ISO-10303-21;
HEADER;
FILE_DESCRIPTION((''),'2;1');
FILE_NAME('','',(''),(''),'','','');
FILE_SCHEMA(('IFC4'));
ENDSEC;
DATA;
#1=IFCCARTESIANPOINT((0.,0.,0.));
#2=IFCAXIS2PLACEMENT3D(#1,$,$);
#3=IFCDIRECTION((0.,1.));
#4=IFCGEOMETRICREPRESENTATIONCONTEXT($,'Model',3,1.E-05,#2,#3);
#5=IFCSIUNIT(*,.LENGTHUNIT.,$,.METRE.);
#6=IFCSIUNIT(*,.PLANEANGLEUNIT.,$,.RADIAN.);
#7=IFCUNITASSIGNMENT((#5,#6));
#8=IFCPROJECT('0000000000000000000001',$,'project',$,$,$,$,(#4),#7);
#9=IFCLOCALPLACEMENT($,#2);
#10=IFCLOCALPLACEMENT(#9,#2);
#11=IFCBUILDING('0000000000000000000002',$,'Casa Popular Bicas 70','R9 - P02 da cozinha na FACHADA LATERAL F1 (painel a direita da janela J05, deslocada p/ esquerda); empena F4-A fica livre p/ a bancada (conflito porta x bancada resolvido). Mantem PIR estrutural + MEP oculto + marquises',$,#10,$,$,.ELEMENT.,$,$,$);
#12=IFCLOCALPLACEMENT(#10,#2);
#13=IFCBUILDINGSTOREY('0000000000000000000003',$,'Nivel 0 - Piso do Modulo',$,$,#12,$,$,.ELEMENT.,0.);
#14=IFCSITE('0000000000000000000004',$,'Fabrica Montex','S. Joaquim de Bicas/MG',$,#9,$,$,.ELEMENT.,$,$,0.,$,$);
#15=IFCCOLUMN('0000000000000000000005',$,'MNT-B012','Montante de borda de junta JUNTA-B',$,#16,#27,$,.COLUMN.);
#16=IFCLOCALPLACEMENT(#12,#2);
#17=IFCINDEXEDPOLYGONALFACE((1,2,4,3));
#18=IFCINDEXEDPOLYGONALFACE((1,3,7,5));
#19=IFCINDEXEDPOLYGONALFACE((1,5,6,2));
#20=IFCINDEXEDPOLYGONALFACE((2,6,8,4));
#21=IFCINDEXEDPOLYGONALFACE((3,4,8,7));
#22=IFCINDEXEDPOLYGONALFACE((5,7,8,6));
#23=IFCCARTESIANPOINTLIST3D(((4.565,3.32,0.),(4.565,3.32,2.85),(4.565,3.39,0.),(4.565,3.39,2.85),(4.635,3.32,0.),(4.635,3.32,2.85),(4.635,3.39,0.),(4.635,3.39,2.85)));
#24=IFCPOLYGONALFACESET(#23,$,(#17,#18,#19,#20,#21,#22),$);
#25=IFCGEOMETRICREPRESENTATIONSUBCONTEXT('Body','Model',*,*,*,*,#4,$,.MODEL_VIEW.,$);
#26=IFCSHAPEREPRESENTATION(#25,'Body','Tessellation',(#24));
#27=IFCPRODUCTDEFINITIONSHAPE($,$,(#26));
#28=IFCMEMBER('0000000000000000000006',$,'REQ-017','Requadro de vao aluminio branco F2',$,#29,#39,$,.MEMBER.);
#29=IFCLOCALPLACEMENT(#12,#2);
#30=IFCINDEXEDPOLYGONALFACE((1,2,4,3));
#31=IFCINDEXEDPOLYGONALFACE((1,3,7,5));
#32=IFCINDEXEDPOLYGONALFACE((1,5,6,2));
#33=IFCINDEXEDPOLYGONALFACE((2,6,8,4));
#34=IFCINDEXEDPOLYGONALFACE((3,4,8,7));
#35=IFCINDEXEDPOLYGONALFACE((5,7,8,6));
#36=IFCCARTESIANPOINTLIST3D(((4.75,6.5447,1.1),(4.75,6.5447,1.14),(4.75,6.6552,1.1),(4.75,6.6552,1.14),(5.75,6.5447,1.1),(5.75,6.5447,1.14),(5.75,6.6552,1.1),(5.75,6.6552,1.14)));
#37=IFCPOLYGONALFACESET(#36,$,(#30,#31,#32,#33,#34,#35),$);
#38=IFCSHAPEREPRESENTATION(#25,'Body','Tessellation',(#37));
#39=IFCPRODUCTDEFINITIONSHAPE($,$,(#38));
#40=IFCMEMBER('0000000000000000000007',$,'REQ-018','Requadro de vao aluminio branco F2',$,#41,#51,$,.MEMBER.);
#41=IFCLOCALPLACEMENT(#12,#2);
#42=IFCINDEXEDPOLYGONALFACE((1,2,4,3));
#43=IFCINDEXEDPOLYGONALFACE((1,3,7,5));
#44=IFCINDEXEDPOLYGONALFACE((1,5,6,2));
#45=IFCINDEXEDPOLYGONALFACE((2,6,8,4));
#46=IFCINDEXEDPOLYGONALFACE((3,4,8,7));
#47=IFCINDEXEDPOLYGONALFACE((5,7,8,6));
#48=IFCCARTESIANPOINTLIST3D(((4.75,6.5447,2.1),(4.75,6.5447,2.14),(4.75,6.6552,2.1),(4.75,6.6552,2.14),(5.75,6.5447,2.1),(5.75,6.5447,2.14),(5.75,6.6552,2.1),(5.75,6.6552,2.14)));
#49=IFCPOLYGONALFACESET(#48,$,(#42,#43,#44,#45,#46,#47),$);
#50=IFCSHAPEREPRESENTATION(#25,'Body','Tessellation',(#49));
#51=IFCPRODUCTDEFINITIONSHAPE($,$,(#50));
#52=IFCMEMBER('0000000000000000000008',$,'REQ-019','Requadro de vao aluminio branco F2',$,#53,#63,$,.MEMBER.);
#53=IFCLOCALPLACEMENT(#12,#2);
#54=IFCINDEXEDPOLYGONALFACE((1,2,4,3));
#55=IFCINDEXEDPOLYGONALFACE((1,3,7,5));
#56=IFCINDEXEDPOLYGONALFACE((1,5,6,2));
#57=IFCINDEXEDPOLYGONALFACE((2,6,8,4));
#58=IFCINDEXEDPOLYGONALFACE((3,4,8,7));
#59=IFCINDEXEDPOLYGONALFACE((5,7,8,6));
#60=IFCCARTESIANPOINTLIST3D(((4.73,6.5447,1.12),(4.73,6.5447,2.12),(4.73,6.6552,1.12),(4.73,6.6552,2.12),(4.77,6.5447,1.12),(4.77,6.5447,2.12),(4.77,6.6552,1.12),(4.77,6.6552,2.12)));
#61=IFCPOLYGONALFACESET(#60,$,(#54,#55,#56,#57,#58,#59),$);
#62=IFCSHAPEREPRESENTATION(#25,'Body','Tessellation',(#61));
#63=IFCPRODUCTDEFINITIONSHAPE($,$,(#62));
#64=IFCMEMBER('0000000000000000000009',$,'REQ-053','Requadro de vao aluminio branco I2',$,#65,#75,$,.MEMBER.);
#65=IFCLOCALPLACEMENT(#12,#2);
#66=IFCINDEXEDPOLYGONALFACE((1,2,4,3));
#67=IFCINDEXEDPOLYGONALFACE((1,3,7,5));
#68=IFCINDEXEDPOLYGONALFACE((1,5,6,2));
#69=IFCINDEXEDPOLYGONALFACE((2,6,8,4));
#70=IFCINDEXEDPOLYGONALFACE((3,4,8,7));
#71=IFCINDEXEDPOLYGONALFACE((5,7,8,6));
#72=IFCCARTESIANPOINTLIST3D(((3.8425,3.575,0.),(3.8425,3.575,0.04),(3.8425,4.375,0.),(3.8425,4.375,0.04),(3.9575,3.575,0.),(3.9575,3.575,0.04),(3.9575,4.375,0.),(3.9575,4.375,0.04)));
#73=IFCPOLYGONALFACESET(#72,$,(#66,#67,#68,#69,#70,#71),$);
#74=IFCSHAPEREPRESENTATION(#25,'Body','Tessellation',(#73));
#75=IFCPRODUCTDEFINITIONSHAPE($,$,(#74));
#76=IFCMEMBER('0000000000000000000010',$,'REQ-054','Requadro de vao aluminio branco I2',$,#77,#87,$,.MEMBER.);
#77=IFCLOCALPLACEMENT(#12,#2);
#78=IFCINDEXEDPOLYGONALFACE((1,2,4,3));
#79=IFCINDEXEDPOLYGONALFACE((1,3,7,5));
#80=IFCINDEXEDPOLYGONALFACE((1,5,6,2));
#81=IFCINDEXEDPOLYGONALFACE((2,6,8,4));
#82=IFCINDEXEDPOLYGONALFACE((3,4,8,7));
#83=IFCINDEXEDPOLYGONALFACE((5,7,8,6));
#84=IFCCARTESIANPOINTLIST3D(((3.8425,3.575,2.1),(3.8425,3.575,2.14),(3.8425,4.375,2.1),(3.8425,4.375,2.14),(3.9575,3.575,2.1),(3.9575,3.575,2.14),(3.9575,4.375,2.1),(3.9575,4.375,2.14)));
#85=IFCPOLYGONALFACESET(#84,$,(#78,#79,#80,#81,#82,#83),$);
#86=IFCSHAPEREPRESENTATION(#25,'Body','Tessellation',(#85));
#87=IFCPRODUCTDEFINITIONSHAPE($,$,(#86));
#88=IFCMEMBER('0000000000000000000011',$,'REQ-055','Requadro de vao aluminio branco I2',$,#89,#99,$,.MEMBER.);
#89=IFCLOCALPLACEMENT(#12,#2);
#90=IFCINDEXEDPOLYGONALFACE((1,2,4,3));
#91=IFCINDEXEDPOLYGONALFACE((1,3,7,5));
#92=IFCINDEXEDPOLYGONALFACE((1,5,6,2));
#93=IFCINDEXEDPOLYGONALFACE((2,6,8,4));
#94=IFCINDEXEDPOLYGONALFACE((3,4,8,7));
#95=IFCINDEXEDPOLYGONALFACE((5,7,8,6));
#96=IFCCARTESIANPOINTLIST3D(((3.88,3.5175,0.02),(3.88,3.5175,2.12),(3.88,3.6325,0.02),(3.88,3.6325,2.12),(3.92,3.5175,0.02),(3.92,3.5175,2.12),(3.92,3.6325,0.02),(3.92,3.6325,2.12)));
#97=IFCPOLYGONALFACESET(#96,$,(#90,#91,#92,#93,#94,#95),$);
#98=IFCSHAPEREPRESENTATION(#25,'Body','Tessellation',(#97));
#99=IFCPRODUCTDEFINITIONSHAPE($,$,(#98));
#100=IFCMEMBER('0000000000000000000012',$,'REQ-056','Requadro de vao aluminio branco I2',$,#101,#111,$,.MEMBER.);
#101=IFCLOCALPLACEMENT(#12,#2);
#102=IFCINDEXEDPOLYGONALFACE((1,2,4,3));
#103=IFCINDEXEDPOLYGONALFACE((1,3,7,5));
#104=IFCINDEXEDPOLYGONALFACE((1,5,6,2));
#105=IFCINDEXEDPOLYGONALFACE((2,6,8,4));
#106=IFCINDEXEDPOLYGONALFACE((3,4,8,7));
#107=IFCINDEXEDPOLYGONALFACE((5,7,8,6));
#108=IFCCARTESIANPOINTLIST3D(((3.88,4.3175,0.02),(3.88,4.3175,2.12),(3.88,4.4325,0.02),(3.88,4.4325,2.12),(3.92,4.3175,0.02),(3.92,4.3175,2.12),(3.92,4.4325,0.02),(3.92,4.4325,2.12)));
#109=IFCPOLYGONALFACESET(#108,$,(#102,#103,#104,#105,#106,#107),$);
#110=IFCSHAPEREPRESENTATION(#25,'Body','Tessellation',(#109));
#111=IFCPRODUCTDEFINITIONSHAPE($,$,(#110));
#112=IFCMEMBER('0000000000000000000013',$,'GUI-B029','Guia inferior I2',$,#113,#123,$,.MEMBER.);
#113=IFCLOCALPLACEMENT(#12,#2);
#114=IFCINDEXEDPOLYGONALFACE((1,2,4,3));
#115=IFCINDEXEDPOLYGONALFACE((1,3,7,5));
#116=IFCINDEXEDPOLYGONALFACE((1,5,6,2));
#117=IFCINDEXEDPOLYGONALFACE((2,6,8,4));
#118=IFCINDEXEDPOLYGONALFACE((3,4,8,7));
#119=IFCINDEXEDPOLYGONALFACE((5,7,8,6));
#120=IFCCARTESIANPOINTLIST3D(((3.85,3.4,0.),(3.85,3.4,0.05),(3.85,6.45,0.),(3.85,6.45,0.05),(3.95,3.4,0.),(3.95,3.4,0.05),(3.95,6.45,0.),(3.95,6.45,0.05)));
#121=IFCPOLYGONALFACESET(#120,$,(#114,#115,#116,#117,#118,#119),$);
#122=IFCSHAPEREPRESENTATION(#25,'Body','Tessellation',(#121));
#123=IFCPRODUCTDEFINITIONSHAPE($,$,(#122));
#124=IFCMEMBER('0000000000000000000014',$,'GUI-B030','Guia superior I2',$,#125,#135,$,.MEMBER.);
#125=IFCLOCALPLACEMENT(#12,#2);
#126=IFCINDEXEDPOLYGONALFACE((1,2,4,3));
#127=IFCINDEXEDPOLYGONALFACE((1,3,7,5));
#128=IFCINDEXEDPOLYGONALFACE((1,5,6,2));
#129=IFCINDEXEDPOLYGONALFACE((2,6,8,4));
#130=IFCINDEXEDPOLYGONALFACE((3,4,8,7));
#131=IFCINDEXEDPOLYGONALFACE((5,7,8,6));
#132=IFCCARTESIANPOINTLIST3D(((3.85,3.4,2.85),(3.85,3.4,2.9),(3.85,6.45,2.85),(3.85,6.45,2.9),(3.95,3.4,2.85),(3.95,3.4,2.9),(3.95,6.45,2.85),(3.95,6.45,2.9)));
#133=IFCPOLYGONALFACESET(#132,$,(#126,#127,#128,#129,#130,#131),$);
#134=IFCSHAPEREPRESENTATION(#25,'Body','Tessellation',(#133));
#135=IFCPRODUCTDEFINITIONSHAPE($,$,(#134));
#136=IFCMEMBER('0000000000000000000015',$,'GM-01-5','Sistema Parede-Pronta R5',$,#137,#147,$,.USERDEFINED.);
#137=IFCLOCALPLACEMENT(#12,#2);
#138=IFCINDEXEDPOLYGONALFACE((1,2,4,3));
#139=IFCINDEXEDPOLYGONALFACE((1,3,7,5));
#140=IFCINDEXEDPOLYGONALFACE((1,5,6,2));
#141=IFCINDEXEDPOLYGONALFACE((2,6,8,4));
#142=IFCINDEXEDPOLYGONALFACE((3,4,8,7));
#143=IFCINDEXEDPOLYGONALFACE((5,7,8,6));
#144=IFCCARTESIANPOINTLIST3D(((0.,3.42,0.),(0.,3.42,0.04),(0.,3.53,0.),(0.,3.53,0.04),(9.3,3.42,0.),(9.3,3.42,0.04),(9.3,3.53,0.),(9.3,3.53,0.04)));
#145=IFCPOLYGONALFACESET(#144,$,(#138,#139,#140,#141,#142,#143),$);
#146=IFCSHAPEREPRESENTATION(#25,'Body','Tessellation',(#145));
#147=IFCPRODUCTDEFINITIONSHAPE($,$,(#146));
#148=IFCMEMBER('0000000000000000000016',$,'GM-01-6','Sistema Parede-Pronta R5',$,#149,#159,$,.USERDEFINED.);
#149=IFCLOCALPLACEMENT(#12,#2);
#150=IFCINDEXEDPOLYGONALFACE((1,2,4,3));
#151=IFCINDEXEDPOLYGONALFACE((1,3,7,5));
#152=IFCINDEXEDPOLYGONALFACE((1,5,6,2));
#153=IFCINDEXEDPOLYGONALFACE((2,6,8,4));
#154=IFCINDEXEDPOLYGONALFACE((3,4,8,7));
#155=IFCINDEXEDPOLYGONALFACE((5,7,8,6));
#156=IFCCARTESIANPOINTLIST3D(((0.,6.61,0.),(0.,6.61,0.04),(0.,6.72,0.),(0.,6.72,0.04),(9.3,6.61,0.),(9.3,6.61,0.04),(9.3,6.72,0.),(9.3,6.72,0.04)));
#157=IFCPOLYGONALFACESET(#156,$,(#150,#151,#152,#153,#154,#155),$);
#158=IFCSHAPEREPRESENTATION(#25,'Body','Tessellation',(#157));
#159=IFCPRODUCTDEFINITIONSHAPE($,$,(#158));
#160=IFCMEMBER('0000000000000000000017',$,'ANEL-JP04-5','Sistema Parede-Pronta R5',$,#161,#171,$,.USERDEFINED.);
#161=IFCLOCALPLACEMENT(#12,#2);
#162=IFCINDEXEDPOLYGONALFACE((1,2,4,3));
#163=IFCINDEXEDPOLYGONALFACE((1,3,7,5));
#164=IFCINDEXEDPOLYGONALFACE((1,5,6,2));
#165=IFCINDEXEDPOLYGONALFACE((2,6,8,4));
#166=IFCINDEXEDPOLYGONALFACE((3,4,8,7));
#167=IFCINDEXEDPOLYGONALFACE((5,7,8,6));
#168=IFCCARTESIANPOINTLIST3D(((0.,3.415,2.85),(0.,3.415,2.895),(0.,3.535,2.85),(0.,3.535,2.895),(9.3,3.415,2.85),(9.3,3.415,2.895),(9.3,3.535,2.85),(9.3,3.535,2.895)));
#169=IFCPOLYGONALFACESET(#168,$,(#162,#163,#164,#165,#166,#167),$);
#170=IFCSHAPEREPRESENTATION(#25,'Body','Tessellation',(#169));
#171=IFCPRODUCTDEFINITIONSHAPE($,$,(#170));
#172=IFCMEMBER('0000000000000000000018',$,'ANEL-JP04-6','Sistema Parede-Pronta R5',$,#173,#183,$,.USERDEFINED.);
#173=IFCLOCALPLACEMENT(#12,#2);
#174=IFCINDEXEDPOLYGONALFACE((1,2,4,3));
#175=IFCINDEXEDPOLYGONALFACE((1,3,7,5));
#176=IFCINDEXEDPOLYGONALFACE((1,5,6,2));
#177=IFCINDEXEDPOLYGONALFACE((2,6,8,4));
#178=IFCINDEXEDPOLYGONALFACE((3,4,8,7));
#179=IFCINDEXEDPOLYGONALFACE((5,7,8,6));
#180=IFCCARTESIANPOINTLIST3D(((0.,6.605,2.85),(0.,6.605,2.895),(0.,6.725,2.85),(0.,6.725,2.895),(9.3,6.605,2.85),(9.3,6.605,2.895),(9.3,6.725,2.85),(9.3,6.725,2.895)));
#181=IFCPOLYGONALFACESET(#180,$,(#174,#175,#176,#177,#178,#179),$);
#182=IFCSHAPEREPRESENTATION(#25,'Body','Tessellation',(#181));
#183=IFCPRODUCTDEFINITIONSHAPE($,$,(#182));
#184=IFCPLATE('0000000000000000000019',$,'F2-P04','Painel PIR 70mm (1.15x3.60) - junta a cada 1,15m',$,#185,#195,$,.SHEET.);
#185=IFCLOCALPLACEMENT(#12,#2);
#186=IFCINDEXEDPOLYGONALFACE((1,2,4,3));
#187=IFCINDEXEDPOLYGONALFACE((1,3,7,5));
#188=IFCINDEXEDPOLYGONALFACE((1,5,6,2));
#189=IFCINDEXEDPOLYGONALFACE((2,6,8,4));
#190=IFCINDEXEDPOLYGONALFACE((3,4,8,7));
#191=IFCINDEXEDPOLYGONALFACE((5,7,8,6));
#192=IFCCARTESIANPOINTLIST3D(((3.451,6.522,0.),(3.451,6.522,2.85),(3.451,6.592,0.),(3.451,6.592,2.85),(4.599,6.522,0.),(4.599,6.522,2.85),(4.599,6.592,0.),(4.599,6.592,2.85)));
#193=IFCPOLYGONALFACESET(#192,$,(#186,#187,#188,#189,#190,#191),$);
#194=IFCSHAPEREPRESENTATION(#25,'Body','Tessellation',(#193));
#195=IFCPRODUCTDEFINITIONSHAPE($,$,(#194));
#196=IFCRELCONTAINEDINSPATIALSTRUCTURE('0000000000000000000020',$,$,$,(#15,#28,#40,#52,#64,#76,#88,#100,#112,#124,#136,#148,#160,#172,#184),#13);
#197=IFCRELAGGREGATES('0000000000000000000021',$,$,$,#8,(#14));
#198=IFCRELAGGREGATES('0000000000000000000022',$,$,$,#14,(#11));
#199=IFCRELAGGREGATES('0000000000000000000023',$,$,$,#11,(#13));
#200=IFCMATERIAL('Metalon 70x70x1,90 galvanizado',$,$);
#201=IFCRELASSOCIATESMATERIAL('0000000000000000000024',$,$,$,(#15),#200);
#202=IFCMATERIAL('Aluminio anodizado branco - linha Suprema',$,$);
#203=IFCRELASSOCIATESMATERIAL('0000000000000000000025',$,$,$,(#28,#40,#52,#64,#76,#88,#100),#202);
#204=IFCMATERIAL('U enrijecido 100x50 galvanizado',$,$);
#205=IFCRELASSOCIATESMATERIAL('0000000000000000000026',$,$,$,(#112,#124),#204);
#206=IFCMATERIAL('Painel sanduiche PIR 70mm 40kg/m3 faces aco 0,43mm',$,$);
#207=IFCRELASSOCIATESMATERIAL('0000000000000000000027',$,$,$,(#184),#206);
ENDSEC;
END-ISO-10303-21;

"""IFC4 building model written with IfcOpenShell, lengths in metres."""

from ifc_helpers import new_model, si_unit, direction, frame, frame_2d, origin, origin_2d, place, context, subcontext, project, spatial, rectangle, extrude, material, element, save


model = new_model("IFC4")

# Units and contexts
model_context = context("Model", 3, precision=1e-05, world=origin(), true_north=direction((0.0, 1.0)))
body_context = subcontext(model_context, "Body", "Model", "MODEL_VIEW")
ifc_project = project(units=[si_unit("LENGTHUNIT", "METRE"), si_unit("PLANEANGLEUNIT", "RADIAN")], contexts=[model_context])

# Site, building, storey
site_placement = place(None, origin())
site = spatial("IfcSite", under=ifc_project, at=site_placement, Name="Fabrica Montex", Description="S. Joaquim de Bicas/MG", CompositionType="ELEMENT", RefElevation=0.0)
building_placement = place(site_placement, origin())
building = spatial("IfcBuilding", under=site, at=building_placement, Name="Casa Popular Bicas 70", Description="R9 - P02 da cozinha na FACHADA LATERAL F1 (painel a direita da janela J05, deslocada p/ esquerda); empena F4-A fica livre p/ a bancada (conflito porta x bancada resolvido). Mantem PIR estrutural + MEP oculto + marquises", CompositionType="ELEMENT")
storey_placement = place(building_placement, origin())
storey = spatial("IfcBuildingStorey", under=building, at=storey_placement, Name="Nivel 0 - Piso do Modulo", CompositionType="ELEMENT", Elevation=0.0)

# Column
ifc_material_1 = material(Name="Metalon 70x70x1,90 galvanizado")
column_placement = place(storey_placement, frame((4.6, 3.355, 0.0)))
element("IfcColumn", 1, at=column_placement, inside=storey, material=ifc_material_1, Name="MNT-B012", Description="Montante de borda de junta JUNTA-B", PredefinedType="COLUMN", context=body_context, shape_type="SweptSolid", body=[
    extrude(rectangle(XDim=0.07, YDim=0.07, at=origin_2d()), origin(), (0.0, 0.0, 1.0), 2.85),
])

# Members
ifc_material_2 = material(Name="Aluminio anodizado branco - linha Suprema")
for number, where, z_axis, x_axis, name in (
    (2, (4.75, 6.6, 1.12), (1.0, 0.0, 0.0), (0.0, 0.0, 1.0), "REQ-017"),
    (3, (4.75, 6.6, 2.12), (1.0, 0.0, 0.0), (0.0, 0.0, 1.0), "REQ-018"),
    (4, (4.75, 6.6, 1.12), (0.0, 0.0, 1.0), (1.0, 0.0, 0.0), "REQ-019"),
):
    element("IfcMember", number, at=place(storey_placement, frame(where, z_axis=z_axis, x_axis=x_axis)), inside=storey, material=ifc_material_2, Name=name, Description="Requadro de vao aluminio branco F2", PredefinedType="MEMBER", context=body_context, shape_type="SweptSolid", body=[
        extrude(rectangle(XDim=0.04, YDim=0.1105, at=origin_2d()), origin(), (0.0, 0.0, 1.0), 1.0),
    ])
for number, where, z_axis, x_axis, name in (
    (5, (3.9, 3.575, 0.02), (0.0, 1.0, 0.0), (0.0, 0.0, 1.0), "REQ-053"),
    (6, (3.9, 3.575, 2.12), (0.0, 1.0, 0.0), (0.0, 0.0, 1.0), "REQ-054"),
):
    element("IfcMember", number, at=place(storey_placement, frame(where, z_axis=z_axis, x_axis=x_axis)), inside=storey, material=ifc_material_2, Name=name, Description="Requadro de vao aluminio branco I2", PredefinedType="MEMBER", context=body_context, shape_type="SweptSolid", body=[
        extrude(rectangle(XDim=0.04, YDim=0.115, at=origin_2d()), origin(), (0.0, 0.0, 1.0), 0.8),
    ])
for number, where, z_axis, x_axis, name in (
    (7, (3.9, 3.575, 0.02), (0.0, 0.0, 1.0), (1.0, 0.0, 0.0), "REQ-055"),
    (8, (3.9, 4.375, 0.02), (0.0, 0.0, 1.0), (1.0, 0.0, 0.0), "REQ-056"),
):
    element("IfcMember", number, at=place(storey_placement, frame(where, z_axis=z_axis, x_axis=x_axis)), inside=storey, material=ifc_material_2, Name=name, Description="Requadro de vao aluminio branco I2", PredefinedType="MEMBER", context=body_context, shape_type="SweptSolid", body=[
        extrude(rectangle(XDim=0.04, YDim=0.115, at=origin_2d()), origin(), (0.0, 0.0, 1.0), 2.1),
    ])
ifc_material_3 = material(Name="U enrijecido 100x50 galvanizado")
for number, where, z_axis, x_axis, name, description in (
    (9, (3.9, 3.4, 0.025), (0.0, 1.0, 0.0), (0.0, 0.0, 1.0), "GUI-B029", "Guia inferior I2"),
    (10, (3.9, 3.4, 2.875), (0.0, 1.0, 0.0), (0.0, 0.0, 1.0), "GUI-B030", "Guia superior I2"),
):
    element("IfcMember", number, at=place(storey_placement, frame(where, z_axis=z_axis, x_axis=x_axis)), inside=storey, material=ifc_material_3, Name=name, Description=description, PredefinedType="MEMBER", context=body_context, shape_type="SweptSolid", body=[
        extrude(rectangle(XDim=0.05, YDim=0.1, at=origin_2d()), origin(), (0.0, 0.0, 1.0), 3.05),
    ])
for number, where, name in (
    (11, (4.65, 3.475, 0.0), "GM-01-5"),
    (12, (4.65, 6.665, 0.0), "GM-01-6"),
):
    element("IfcMember", number, at=place(storey_placement, frame(where)), inside=storey, Name=name, Description="Sistema Parede-Pronta R5", PredefinedType="USERDEFINED", context=body_context, shape_type="SweptSolid", body=[
        extrude(rectangle(XDim=9.3, YDim=0.11, at=origin_2d()), origin(), (0.0, 0.0, 1.0), 0.04),
    ])
for number, where, name in (
    (13, (4.65, 3.475, 2.85), "ANEL-JP04-5"),
    (14, (4.65, 6.665, 2.85), "ANEL-JP04-6"),
):
    element("IfcMember", number, at=place(storey_placement, frame(where)), inside=storey, Name=name, Description="Sistema Parede-Pronta R5", PredefinedType="USERDEFINED", context=body_context, shape_type="SweptSolid", body=[
        extrude(rectangle(XDim=9.3, YDim=0.12, at=origin_2d()), origin(), (0.0, 0.0, 1.0), 0.045),
    ])

# Plate
ifc_material_4 = material(Name="Painel sanduiche PIR 70mm 40kg/m3 faces aco 0,43mm")
plate_1_placement = place(storey_placement, frame((3.451, 6.557, 0.0), x_axis=(1.0, 0.0, 0.0)))
element("IfcPlate", 15, at=plate_1_placement, inside=storey, material=ifc_material_4, Name="F2-P04", Description="Painel PIR 70mm (1.15x3.60) - junta a cada 1,15m", PredefinedType="SHEET", context=body_context, shape_type="SweptSolid", body=[
    extrude(rectangle(XDim=1.148, YDim=0.07, at=frame_2d((0.574, 0.0))), origin(), (0.0, 0.0, 1.0), 2.85),
])

save(model, "model.ifc")
